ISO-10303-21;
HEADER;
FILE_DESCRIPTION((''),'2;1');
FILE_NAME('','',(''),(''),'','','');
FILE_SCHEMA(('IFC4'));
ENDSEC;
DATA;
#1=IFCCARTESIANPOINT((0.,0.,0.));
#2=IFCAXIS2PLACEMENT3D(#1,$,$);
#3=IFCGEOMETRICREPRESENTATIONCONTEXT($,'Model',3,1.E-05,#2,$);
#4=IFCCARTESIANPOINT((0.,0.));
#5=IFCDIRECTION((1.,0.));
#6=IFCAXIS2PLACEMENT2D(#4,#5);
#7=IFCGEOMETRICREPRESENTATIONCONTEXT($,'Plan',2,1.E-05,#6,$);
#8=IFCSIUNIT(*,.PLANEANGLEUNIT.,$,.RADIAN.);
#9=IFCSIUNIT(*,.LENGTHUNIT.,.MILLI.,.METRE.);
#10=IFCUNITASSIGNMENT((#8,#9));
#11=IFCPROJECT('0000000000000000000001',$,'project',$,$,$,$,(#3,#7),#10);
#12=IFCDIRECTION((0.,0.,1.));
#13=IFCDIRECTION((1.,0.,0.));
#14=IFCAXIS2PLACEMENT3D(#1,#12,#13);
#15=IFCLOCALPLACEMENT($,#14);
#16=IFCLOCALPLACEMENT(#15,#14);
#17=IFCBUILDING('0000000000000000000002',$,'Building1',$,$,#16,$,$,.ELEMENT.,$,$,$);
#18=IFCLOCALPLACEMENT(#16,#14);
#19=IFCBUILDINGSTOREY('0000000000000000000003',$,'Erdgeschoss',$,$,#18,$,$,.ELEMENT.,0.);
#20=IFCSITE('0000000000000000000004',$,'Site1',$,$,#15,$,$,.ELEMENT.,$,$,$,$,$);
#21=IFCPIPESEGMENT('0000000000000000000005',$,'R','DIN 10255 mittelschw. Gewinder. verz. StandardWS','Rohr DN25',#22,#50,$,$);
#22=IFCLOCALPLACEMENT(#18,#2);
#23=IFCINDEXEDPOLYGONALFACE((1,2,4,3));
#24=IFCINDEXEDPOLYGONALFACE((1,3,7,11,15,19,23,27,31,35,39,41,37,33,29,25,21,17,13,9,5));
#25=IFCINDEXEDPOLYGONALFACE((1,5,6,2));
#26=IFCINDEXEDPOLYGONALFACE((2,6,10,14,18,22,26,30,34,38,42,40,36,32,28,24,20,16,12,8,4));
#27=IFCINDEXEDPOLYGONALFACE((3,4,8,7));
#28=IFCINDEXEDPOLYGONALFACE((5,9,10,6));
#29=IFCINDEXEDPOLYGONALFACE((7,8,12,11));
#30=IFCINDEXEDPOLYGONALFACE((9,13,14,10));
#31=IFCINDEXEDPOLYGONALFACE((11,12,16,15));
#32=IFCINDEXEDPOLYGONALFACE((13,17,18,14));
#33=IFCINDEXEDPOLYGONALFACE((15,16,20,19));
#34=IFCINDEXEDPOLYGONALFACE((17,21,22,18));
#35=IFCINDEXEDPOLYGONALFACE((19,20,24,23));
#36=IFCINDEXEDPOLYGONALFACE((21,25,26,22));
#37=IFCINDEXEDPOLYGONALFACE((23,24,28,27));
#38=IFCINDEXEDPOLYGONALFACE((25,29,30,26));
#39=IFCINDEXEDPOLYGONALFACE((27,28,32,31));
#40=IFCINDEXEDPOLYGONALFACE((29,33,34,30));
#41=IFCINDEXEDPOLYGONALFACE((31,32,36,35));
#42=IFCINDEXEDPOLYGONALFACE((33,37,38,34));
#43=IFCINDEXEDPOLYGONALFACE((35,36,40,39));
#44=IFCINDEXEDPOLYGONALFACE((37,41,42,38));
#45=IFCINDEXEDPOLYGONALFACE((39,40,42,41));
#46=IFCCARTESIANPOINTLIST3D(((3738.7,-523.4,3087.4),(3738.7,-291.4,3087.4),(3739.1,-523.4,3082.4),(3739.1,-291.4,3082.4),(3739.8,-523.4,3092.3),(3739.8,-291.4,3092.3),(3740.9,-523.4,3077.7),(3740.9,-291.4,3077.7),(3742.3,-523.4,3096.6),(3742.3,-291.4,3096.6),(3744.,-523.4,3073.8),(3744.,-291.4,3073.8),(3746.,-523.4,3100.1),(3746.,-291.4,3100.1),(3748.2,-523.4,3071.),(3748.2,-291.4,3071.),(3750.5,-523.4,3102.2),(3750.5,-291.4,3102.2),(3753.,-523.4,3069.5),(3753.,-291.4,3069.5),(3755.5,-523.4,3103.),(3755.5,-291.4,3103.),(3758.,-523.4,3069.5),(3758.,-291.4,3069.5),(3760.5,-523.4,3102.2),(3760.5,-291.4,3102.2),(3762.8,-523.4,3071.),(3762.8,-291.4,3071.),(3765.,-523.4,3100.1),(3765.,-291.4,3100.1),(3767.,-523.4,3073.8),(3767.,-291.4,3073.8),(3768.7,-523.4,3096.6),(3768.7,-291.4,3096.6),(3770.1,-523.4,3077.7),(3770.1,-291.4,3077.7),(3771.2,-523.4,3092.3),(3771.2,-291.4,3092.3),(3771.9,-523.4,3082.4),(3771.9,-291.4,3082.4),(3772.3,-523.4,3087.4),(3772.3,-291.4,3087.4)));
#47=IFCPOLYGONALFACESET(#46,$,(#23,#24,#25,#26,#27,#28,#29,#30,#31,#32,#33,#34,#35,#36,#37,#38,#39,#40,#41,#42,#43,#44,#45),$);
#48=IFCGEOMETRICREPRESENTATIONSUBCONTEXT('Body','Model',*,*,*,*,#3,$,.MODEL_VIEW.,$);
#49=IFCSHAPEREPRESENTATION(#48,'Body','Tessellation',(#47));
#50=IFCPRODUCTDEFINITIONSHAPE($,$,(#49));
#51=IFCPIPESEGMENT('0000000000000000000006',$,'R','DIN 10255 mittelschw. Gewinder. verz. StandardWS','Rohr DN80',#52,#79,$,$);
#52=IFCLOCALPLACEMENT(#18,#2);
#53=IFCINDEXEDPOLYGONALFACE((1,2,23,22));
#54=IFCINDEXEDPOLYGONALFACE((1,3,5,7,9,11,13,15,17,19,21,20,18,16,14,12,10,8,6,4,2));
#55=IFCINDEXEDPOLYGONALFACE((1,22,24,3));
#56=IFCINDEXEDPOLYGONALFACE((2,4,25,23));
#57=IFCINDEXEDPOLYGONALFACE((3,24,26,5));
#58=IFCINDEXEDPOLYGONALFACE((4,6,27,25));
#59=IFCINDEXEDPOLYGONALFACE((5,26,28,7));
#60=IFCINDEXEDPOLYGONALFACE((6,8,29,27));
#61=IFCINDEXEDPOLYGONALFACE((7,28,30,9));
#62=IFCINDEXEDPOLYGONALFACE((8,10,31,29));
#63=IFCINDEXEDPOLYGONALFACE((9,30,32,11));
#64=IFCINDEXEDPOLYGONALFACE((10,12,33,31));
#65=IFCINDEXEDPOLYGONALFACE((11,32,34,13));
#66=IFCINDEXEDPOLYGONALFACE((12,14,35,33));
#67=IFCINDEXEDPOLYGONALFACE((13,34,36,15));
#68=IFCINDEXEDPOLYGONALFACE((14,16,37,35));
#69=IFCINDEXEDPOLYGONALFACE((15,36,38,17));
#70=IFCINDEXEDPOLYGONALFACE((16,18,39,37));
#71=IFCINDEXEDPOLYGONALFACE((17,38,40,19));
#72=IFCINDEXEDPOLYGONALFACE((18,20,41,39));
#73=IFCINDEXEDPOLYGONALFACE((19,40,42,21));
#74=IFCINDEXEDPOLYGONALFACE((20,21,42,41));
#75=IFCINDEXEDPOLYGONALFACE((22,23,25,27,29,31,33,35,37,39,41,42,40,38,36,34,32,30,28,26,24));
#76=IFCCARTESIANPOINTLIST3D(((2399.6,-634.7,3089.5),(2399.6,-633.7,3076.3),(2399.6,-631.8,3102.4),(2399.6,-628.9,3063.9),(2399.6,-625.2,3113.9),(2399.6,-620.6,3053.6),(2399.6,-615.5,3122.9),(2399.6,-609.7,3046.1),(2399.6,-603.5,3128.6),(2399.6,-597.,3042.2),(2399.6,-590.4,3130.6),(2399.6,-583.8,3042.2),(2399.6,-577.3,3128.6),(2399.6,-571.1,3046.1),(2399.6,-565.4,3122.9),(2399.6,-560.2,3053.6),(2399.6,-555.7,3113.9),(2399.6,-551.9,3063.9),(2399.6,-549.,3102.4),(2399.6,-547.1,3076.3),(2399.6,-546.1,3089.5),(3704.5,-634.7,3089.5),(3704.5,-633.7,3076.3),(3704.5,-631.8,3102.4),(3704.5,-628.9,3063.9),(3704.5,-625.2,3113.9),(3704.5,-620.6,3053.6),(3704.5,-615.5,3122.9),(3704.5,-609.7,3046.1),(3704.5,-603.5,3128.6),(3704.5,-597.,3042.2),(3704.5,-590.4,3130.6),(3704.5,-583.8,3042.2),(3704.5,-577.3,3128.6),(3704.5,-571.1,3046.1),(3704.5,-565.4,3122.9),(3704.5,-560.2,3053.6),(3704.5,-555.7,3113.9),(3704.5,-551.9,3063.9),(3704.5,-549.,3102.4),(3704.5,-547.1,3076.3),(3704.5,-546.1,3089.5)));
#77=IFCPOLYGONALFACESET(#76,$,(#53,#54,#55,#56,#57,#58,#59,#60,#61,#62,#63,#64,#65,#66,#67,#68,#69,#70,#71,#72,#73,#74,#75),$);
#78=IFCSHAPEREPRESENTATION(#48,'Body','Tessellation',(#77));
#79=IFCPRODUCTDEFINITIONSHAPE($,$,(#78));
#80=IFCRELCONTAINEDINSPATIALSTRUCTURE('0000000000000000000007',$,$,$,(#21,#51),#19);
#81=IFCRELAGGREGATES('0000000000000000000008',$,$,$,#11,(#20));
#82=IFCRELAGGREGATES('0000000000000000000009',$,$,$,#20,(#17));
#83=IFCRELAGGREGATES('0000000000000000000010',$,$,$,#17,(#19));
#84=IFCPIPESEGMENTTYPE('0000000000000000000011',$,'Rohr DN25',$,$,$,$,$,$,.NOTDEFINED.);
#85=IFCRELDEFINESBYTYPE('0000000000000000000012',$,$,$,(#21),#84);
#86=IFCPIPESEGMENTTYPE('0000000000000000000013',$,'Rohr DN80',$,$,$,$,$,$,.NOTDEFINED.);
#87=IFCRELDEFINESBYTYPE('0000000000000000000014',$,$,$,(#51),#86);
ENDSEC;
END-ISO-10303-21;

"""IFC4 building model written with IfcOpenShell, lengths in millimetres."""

from ifc_helpers import new_model, si_unit, frame, origin, origin_with_axes, origin_2d_with_axis, place, context, subcontext, project, spatial, circle, extrude, type_object, element, save


model = new_model("IFC4")

# Units and contexts
model_context = context("Model", 3, precision=1e-05, world=origin())
plan_context = context("Plan", 2, precision=1e-05, world=origin_2d_with_axis())
body_context = subcontext(model_context, "Body", "Model", "MODEL_VIEW")
ifc_project = project(units=[si_unit("PLANEANGLEUNIT", "RADIAN"), si_unit("LENGTHUNIT", "METRE", prefix="MILLI")], contexts=[model_context, plan_context])

# Site, building, storey
site_placement = place(None, origin_with_axes())
site = spatial("IfcSite", under=ifc_project, at=site_placement, Name="Site1", CompositionType="ELEMENT")
building_placement = place(site_placement, origin_with_axes())
building = spatial("IfcBuilding", under=site, at=building_placement, Name="Building1", CompositionType="ELEMENT")
storey_placement = place(building_placement, origin_with_axes())
storey = spatial("IfcBuildingStorey", under=building, at=storey_placement, Name="Erdgeschoss", CompositionType="ELEMENT", Elevation=0.0)

# Pipe segments
pipe_segment_type_1 = type_object("IfcPipeSegmentType", Name="Rohr DN25", PredefinedType="NOTDEFINED")
pipe_segment_1_placement = place(storey_placement, frame((3755.3, -407.4, 3086.1), z_axis=(0.0, 0.0, 1.0), x_axis=(1.0, 0.0, 0.0)))
element("IfcPipeSegment", 1, at=pipe_segment_1_placement, inside=storey, type_object=pipe_segment_type_1, Name="R", Description="DIN 10255 mittelschw. Gewinder. verz. StandardWS", ObjectType="Rohr DN25", context=body_context, shape_type="SolidModel", body=[
    extrude(circle(Radius=16.9, at=origin_2d_with_axis()), frame((0.2, -116.0, 0.0), z_axis=(0.0, 1.0, 0.0), x_axis=(0.0, 0.0, 1.0)), (0.0, 0.0, 1.0), 232.0),
])
pipe_segment_type_2 = type_object("IfcPipeSegmentType", Name="Rohr DN80", PredefinedType="NOTDEFINED")
pipe_segment_2_placement = place(storey_placement, frame((3052.0, -590.3, 3086.1), z_axis=(0.0, 0.0, 1.0), x_axis=(1.0, 0.0, 0.0)))
element("IfcPipeSegment", 2, at=pipe_segment_2_placement, inside=storey, type_object=pipe_segment_type_2, Name="R", Description="DIN 10255 mittelschw. Gewinder. verz. StandardWS", ObjectType="Rohr DN80", context=body_context, shape_type="SolidModel", body=[
    extrude(circle(Radius=44.5, at=origin_2d_with_axis()), frame((-652.5, -0.2, 0.0), z_axis=(1.0, 0.0, 0.0), x_axis=(0.0, 0.0, 1.0)), (0.0, 0.0, 1.0), 1304.9),
])

save(model, "model.ifc")
